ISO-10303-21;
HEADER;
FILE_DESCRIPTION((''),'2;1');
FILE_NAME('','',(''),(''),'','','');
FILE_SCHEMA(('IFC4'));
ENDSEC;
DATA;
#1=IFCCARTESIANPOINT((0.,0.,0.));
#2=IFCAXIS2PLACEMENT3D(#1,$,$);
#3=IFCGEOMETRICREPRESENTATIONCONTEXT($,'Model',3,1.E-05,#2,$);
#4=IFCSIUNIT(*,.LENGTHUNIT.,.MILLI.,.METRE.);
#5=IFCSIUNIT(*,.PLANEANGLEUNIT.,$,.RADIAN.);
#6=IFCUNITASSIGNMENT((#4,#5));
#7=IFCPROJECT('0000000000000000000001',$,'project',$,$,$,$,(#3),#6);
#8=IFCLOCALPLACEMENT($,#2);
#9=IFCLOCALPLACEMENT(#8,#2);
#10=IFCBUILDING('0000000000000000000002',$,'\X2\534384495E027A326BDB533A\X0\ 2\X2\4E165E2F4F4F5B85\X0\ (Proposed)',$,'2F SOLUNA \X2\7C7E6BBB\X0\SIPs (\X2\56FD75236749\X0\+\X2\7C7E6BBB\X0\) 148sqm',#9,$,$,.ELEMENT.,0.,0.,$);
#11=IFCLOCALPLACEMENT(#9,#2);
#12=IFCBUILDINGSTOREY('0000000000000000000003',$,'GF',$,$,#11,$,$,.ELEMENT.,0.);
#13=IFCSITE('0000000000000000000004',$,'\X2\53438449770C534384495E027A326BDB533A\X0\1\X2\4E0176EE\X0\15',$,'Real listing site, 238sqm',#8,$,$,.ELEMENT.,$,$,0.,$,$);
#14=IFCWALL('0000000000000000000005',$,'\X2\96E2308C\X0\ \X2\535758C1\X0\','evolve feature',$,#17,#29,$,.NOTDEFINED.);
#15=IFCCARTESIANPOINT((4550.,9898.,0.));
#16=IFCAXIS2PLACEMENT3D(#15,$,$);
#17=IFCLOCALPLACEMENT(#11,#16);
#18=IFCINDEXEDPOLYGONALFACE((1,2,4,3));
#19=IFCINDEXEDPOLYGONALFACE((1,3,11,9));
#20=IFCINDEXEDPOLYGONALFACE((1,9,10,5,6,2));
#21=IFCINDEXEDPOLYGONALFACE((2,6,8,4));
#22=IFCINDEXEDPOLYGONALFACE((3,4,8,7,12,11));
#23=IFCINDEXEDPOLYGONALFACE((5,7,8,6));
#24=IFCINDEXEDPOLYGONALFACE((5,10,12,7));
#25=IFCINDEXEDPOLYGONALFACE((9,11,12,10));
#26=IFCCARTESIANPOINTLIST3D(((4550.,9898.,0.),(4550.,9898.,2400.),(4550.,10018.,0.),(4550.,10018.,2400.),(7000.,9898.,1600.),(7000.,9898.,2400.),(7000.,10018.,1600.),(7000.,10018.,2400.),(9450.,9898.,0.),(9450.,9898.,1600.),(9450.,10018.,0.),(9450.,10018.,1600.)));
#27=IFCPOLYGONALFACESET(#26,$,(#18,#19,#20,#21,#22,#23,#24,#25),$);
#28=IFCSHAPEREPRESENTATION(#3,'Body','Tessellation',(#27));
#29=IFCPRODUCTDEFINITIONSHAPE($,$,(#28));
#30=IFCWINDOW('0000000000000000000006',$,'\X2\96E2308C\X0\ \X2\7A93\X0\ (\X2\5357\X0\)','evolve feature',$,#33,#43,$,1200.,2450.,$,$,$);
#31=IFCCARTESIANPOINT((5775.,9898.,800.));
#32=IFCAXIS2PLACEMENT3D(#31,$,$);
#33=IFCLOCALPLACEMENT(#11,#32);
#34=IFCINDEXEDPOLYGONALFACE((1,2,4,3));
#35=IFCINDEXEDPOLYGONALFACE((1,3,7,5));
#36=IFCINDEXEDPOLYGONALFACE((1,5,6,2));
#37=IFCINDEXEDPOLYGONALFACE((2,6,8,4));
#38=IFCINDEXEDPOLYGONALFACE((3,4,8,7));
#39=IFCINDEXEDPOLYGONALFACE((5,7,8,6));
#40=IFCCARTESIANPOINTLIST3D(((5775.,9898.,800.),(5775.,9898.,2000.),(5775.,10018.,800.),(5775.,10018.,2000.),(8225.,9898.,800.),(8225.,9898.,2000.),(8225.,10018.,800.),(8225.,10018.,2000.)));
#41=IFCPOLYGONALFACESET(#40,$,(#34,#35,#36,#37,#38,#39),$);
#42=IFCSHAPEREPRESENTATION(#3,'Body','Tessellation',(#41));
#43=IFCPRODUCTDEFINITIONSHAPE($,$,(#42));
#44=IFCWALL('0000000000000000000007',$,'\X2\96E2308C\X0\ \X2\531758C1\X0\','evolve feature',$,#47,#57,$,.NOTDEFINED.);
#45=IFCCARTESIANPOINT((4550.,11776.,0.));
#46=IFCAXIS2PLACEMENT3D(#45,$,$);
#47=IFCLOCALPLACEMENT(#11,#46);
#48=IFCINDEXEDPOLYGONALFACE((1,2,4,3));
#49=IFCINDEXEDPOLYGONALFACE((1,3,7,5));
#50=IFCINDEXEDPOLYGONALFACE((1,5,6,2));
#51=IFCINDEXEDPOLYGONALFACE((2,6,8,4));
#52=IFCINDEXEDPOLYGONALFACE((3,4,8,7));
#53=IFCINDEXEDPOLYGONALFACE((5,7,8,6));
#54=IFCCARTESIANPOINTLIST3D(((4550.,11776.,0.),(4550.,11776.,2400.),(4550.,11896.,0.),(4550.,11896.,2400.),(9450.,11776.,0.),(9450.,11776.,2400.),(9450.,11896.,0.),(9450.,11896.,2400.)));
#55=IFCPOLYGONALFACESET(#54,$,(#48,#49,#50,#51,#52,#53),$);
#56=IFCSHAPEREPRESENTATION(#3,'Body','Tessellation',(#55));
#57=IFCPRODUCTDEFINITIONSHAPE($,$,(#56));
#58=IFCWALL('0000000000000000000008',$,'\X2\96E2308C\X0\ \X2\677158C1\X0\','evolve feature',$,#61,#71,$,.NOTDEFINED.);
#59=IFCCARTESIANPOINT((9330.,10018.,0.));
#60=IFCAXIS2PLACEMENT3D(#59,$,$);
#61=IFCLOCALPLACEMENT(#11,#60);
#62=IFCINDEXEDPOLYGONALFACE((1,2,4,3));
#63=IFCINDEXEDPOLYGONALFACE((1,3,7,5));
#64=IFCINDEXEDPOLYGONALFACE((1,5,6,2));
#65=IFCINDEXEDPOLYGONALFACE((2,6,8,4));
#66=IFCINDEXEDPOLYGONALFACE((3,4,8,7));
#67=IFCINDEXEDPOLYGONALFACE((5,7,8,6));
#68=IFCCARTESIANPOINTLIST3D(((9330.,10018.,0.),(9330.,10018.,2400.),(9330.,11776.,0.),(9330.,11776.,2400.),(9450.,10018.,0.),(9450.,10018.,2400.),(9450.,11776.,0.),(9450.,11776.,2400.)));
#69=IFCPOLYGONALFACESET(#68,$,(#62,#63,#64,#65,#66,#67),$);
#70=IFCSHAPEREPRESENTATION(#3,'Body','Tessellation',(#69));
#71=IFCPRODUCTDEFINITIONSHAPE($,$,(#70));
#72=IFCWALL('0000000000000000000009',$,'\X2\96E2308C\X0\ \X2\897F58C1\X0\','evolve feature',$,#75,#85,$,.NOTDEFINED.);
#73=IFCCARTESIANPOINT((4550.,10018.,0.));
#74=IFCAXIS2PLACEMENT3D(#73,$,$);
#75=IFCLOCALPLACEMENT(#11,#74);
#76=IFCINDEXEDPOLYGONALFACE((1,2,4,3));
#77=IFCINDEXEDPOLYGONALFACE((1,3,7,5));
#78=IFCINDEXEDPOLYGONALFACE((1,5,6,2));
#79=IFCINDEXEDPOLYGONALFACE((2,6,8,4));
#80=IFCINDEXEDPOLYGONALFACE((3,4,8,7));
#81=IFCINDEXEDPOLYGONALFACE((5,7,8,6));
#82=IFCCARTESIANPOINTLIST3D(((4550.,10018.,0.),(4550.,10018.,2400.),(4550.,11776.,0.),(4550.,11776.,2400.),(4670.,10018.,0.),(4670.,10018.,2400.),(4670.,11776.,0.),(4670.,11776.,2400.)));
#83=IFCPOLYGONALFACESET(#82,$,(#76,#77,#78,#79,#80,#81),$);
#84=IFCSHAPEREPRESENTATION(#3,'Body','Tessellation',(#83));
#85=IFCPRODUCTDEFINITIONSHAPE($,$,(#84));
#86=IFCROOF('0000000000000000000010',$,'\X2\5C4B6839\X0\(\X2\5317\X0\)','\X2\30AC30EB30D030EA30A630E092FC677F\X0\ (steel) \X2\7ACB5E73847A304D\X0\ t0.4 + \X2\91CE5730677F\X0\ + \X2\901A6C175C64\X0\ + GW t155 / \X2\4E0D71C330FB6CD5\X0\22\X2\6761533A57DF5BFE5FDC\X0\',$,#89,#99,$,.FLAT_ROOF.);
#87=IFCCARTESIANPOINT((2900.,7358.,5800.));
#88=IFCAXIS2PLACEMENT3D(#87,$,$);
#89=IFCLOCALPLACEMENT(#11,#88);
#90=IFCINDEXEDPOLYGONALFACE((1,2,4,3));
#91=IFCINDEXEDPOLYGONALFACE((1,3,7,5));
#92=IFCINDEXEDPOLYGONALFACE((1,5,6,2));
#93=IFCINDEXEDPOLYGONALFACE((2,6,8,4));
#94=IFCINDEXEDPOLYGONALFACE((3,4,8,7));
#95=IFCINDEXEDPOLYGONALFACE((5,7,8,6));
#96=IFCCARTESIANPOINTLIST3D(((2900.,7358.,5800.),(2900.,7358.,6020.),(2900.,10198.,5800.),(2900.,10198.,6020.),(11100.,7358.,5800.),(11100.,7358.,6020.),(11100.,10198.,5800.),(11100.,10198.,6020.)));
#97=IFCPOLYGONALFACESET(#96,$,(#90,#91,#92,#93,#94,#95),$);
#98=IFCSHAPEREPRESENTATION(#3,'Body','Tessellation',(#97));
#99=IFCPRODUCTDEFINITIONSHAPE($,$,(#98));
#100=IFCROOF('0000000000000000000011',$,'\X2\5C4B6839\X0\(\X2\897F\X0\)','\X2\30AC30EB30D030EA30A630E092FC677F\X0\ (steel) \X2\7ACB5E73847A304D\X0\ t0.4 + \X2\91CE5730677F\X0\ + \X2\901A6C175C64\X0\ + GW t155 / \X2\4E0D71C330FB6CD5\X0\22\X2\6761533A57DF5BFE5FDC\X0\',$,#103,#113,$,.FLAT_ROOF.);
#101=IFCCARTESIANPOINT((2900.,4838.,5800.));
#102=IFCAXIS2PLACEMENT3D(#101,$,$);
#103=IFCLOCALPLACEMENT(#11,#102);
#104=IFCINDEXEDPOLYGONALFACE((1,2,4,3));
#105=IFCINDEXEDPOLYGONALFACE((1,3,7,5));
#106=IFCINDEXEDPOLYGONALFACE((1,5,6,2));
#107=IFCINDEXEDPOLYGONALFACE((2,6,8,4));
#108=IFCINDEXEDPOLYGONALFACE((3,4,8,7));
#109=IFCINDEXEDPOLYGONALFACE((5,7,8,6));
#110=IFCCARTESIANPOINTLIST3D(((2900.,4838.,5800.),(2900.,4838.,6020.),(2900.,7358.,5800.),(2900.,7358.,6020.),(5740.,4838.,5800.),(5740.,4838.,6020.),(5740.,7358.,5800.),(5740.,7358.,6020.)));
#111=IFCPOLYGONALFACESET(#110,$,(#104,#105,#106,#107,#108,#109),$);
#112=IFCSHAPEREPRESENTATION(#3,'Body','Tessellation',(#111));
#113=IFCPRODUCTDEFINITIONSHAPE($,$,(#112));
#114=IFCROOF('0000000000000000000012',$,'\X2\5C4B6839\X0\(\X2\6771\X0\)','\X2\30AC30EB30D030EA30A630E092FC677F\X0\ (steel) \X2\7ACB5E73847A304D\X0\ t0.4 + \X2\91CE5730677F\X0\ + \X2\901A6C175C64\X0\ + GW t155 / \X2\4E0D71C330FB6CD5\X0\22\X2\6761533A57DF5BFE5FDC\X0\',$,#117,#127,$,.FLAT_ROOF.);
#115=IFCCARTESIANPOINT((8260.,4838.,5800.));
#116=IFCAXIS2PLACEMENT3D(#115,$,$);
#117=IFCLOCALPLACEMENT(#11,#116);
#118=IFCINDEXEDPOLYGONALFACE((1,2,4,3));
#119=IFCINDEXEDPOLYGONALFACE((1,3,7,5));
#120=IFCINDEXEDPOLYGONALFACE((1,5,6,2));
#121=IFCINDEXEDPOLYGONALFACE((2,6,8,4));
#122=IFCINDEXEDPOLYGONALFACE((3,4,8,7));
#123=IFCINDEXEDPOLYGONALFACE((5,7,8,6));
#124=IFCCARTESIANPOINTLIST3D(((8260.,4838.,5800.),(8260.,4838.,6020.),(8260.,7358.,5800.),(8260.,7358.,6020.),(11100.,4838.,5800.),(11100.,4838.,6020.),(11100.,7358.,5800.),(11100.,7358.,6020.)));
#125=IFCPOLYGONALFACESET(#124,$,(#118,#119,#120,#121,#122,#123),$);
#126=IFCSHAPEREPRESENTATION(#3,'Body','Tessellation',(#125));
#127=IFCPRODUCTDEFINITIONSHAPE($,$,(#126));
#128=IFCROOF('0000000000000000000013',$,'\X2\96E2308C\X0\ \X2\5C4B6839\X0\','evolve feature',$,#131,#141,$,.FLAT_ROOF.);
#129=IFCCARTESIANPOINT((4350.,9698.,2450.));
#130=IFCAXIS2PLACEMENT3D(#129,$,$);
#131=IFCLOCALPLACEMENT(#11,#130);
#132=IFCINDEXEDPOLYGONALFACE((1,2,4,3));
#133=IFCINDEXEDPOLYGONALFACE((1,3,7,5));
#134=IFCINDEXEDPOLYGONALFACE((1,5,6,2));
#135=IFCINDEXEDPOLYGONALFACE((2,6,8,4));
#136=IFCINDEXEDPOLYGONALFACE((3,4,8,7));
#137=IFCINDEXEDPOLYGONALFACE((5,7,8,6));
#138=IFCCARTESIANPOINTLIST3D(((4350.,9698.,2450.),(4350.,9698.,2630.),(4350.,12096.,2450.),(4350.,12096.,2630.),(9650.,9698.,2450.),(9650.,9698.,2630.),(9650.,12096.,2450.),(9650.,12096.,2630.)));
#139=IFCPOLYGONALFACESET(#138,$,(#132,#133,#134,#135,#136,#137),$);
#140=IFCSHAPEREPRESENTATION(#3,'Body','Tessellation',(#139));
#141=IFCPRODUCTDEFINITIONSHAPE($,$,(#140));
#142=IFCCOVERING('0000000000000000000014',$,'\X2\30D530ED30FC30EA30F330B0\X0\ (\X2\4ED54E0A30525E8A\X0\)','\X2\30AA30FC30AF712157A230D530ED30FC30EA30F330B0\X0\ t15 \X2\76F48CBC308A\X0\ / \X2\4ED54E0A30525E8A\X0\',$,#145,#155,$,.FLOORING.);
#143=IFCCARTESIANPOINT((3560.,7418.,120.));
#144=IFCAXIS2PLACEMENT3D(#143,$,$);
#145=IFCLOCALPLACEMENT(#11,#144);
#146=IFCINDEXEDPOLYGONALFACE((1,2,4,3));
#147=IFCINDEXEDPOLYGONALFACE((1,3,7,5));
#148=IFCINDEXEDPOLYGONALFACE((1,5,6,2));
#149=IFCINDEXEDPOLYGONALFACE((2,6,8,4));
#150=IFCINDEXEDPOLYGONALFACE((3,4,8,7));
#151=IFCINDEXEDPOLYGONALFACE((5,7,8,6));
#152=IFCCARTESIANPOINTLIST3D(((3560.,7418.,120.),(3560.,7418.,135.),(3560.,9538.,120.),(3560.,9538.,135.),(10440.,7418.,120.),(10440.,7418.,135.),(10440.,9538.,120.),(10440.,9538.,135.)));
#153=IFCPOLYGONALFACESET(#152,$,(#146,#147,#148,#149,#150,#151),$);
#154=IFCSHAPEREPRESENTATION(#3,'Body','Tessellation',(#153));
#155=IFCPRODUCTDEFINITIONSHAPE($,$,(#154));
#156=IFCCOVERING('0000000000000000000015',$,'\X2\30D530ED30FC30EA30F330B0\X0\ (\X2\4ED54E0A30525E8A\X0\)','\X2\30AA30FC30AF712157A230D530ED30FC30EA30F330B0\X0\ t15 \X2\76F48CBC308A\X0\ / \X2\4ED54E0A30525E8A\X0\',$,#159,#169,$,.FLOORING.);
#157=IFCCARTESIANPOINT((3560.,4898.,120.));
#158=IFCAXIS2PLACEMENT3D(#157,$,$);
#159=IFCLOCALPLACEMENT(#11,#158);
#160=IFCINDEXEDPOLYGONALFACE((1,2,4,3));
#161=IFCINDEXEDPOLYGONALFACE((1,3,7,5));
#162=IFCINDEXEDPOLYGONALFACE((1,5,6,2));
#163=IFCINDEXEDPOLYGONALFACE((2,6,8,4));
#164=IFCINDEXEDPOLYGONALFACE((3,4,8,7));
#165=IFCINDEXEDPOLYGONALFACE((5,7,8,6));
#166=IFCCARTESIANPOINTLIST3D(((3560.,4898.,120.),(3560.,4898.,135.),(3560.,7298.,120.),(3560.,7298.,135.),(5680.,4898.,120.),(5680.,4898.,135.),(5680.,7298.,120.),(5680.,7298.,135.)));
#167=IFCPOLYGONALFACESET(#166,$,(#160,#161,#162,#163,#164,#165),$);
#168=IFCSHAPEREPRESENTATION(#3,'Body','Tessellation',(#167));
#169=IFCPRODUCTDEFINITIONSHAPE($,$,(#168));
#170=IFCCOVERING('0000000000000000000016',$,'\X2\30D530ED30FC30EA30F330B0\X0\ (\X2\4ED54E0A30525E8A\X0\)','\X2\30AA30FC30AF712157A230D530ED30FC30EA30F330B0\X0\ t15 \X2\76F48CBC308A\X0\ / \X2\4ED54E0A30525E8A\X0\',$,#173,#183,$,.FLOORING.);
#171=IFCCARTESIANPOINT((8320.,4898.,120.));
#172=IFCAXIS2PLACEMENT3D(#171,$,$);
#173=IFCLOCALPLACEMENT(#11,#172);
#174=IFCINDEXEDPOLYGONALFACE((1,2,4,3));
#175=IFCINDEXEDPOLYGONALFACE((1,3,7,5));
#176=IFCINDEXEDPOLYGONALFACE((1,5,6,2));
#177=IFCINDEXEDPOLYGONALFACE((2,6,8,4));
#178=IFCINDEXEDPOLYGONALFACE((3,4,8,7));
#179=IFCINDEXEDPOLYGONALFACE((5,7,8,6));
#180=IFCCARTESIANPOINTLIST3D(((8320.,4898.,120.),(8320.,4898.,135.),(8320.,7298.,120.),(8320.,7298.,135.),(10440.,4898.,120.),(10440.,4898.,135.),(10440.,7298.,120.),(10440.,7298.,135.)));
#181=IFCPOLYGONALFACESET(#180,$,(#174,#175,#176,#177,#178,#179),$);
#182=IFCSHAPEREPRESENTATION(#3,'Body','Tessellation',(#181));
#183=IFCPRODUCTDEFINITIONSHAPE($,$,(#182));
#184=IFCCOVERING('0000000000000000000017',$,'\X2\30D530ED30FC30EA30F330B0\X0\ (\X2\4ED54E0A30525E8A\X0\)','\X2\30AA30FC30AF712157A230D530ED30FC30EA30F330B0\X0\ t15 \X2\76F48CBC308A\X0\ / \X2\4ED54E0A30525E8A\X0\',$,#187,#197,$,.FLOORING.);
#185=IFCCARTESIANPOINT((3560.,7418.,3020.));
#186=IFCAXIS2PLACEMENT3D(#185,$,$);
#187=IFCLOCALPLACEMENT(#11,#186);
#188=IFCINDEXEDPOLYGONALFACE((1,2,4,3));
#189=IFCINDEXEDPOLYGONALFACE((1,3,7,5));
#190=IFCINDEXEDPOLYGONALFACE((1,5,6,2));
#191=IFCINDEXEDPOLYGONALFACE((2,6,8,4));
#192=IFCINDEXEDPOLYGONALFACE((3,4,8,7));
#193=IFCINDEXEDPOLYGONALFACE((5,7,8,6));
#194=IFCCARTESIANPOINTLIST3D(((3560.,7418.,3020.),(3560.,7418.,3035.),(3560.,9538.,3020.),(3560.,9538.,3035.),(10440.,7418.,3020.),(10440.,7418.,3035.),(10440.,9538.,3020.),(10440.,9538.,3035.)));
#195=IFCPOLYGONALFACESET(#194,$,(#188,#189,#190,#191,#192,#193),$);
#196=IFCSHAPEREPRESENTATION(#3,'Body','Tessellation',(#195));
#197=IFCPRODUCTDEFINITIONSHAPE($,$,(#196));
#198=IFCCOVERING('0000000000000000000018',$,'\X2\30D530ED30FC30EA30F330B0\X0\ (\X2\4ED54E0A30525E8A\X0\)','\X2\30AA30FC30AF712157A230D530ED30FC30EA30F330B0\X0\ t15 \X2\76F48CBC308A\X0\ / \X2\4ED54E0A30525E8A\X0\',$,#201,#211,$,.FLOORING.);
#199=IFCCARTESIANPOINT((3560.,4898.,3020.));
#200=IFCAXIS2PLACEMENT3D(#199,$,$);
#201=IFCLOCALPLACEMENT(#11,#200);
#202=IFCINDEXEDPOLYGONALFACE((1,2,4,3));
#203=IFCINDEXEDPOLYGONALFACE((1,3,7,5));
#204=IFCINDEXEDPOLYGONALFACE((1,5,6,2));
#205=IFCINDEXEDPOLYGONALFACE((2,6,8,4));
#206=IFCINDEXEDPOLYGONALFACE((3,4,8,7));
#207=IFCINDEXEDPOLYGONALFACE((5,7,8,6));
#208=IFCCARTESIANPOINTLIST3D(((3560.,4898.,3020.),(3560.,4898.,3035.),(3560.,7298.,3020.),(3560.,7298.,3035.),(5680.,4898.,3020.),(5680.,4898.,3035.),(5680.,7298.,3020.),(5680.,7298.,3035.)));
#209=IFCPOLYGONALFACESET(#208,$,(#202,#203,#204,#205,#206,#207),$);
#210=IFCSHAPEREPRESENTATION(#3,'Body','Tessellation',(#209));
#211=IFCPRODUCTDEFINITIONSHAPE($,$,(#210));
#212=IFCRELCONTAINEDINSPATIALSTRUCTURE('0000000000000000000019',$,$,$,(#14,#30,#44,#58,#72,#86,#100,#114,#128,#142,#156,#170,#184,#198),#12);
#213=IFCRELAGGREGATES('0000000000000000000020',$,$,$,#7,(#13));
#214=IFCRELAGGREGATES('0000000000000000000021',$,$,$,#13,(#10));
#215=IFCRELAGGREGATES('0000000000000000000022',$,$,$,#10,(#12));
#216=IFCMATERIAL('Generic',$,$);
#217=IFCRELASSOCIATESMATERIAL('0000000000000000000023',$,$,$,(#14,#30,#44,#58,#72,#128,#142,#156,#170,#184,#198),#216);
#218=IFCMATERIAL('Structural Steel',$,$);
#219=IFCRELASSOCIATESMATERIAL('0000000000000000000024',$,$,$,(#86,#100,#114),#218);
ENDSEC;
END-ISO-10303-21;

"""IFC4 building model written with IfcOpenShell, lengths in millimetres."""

from ifc_helpers import new_model, si_unit, frame, frame_2d, origin, place, context, project, spatial, rectangle, extrude, material, element, fill, save


model = new_model("IFC4")

# Units and contexts
model_context = context("Model", 3, precision=1e-05, world=origin())
ifc_project = project(units=[si_unit("LENGTHUNIT", "METRE", prefix="MILLI"), si_unit("PLANEANGLEUNIT", "RADIAN")], contexts=[model_context])

# Site, building, storey
site_placement = place(None, origin())
site = spatial("IfcSite", under=ifc_project, at=site_placement, Name="千葉県千葉市稲毛区1丁目15", ObjectType="Real listing site, 238sqm", CompositionType="ELEMENT", RefElevation=0.0)
building_placement = place(site_placement, origin())
building = spatial("IfcBuilding", under=site, at=building_placement, Name="千葉市稲毛区 2世帯住宅 (Proposed)", ObjectType="2F SOLUNA 籾殻SIPs (国産杉+籾殻) 148sqm", CompositionType="ELEMENT", ElevationOfRefHeight=0.0, ElevationOfTerrain=0.0)
storey_placement = place(building_placement, origin())
storey = spatial("IfcBuildingStorey", under=building, at=storey_placement, Name="GF", CompositionType="ELEMENT", Elevation=0.0)

# Shared definitions
ifc_material_1 = material(Name="Generic")

# Wall, opening, window
wall_1_placement = place(storey_placement, frame((4550.0, 9898.0, 0.0)))
wall_1 = element("IfcWall", 1, at=wall_1_placement, inside=storey, material=ifc_material_1, Name="離れ 南壁", Description="evolve feature", PredefinedType="NOTDEFINED", context=model_context, shape_type="SweptSolid", body=[
    extrude(rectangle(XDim=4900.0, YDim=120.0, at=frame_2d((2450.0, 60.0))), frame((4550.0, 9898.0, 0.0)), (0.0, 0.0, 1.0), 2400.0),
])
opening_1_placement = place(storey_placement, frame((5775.0, 9898.0, 800.0)))
opening_1 = element("IfcOpeningElement", 2, at=opening_1_placement, cuts=wall_1, PredefinedType="NOTDEFINED", context=model_context, shape_type="SweptSolid", body=[
    extrude(rectangle(XDim=2450.0, YDim=120.0, at=frame_2d((1225.0, 60.0))), frame((5775.0, 9898.0, 800.0)), (0.0, 0.0, 1.0), 1200.0),
])
window_1_placement = place(storey_placement, frame((5775.0, 9898.0, 800.0)))
window_1 = element("IfcWindow", 3, at=window_1_placement, inside=storey, material=ifc_material_1, Name="離れ 窓 (南)", Description="evolve feature", OverallHeight=1200.0, OverallWidth=2450.0, context=model_context, shape_type="SweptSolid", body=[
    extrude(rectangle(XDim=2450.0, YDim=120.0, at=frame_2d((1225.0, 60.0))), frame((5775.0, 9898.0, 800.0)), (0.0, 0.0, 1.0), 1200.0),
])
fill(opening_1, window_1)

# Walls
wall_2_placement = place(storey_placement, frame((4550.0, 11776.0, 0.0)))
element("IfcWall", 4, at=wall_2_placement, inside=storey, material=ifc_material_1, Name="離れ 北壁", Description="evolve feature", PredefinedType="NOTDEFINED", context=model_context, shape_type="SweptSolid", body=[
    extrude(rectangle(XDim=4900.0, YDim=120.0, at=frame_2d((2450.0, 60.0))), frame((4550.0, 11776.0, 0.0)), (0.0, 0.0, 1.0), 2400.0),
])
wall_3_placement = place(storey_placement, frame((9330.0, 10018.0, 0.0)))
element("IfcWall", 5, at=wall_3_placement, inside=storey, material=ifc_material_1, Name="離れ 東壁", Description="evolve feature", PredefinedType="NOTDEFINED", context=model_context, shape_type="SweptSolid", body=[
    extrude(rectangle(XDim=120.0, YDim=1758.0, at=frame_2d((60.0, 879.0))), frame((9330.0, 10018.0, 0.0)), (0.0, 0.0, 1.0), 2400.0),
])
wall_4_placement = place(storey_placement, frame((4550.0, 10018.0, 0.0)))
element("IfcWall", 6, at=wall_4_placement, inside=storey, material=ifc_material_1, Name="離れ 西壁", Description="evolve feature", PredefinedType="NOTDEFINED", context=model_context, shape_type="SweptSolid", body=[
    extrude(rectangle(XDim=120.0, YDim=1758.0, at=frame_2d((60.0, 879.0))), frame((4550.0, 10018.0, 0.0)), (0.0, 0.0, 1.0), 2400.0),
])

# Roofs
ifc_material_2 = material(Name="Structural Steel")
for number, where, name in (
    (7, (2900.0, 7358.0, 5800.0), "屋根(北)"),
):
    element("IfcRoof", number, at=place(storey_placement, frame(where)), inside=storey, material=ifc_material_2, Name=name, Description="ガルバリウム鋼板 (steel) 立平葺き t0.4 + 野地板 + 通気層 + GW t155 / 不燃・法22条区域対応", PredefinedType="FLAT_ROOF", context=model_context, shape_type="SweptSolid", body=[
        extrude(rectangle(XDim=8200.0, YDim=2840.0, at=frame_2d((4100.0, 1420.0))), frame((2900.0, 7358.0, 5800.0)), (0.0, 0.0, 1.0), 220.0),
    ])
roof_1_placement = place(storey_placement, frame((2900.0, 4838.0, 5800.0)))
element("IfcRoof", 8, at=roof_1_placement, inside=storey, material=ifc_material_2, Name="屋根(西)", Description="ガルバリウム鋼板 (steel) 立平葺き t0.4 + 野地板 + 通気層 + GW t155 / 不燃・法22条区域対応", PredefinedType="FLAT_ROOF", context=model_context, shape_type="SweptSolid", body=[
    extrude(rectangle(XDim=2840.0, YDim=2520.0, at=frame_2d((1420.0, 1260.0))), frame((2900.0, 4838.0, 5800.0)), (0.0, 0.0, 1.0), 220.0),
])
roof_2_placement = place(storey_placement, frame((8260.0, 4838.0, 5800.0)))
element("IfcRoof", 9, at=roof_2_placement, inside=storey, material=ifc_material_2, Name="屋根(東)", Description="ガルバリウム鋼板 (steel) 立平葺き t0.4 + 野地板 + 通気層 + GW t155 / 不燃・法22条区域対応", PredefinedType="FLAT_ROOF", context=model_context, shape_type="SweptSolid", body=[
    extrude(rectangle(XDim=2840.0, YDim=2520.0, at=frame_2d((1420.0, 1260.0))), frame((8260.0, 4838.0, 5800.0)), (0.0, 0.0, 1.0), 220.0),
])
roof_3_placement = place(storey_placement, frame((4350.0, 9698.0, 2450.0)))
element("IfcRoof", 10, at=roof_3_placement, inside=storey, material=ifc_material_1, Name="離れ 屋根", Description="evolve feature", PredefinedType="FLAT_ROOF", context=model_context, shape_type="SweptSolid", body=[
    extrude(rectangle(XDim=5300.0, YDim=2398.0, at=frame_2d((2650.0, 1199.0))), frame((4350.0, 9698.0, 2450.0)), (0.0, 0.0, 1.0), 180.0),
])

# Coverings
covering_1_placement = place(storey_placement, frame((3560.0, 7418.0, 120.0)))
element("IfcCovering", 11, at=covering_1_placement, inside=storey, material=ifc_material_1, Name="フローリング (仕上げ床)", Description="オーク無垢フローリング t15 直貼り / 仕上げ床", PredefinedType="FLOORING", context=model_context, shape_type="SweptSolid", body=[
    extrude(rectangle(XDim=6880.0, YDim=2120.0, at=frame_2d((3440.0, 1060.0))), frame((3560.0, 7418.0, 120.0)), (0.0, 0.0, 1.0), 15.0),
])
covering_2_placement = place(storey_placement, frame((3560.0, 4898.0, 120.0)))
element("IfcCovering", 12, at=covering_2_placement, inside=storey, material=ifc_material_1, Name="フローリング (仕上げ床)", Description="オーク無垢フローリング t15 直貼り / 仕上げ床", PredefinedType="FLOORING", context=model_context, shape_type="SweptSolid", body=[
    extrude(rectangle(XDim=2120.0, YDim=2400.0, at=frame_2d((1060.0, 1200.0))), frame((3560.0, 4898.0, 120.0)), (0.0, 0.0, 1.0), 15.0),
])
covering_3_placement = place(storey_placement, frame((8320.0, 4898.0, 120.0)))
element("IfcCovering", 13, at=covering_3_placement, inside=storey, material=ifc_material_1, Name="フローリング (仕上げ床)", Description="オーク無垢フローリング t15 直貼り / 仕上げ床", PredefinedType="FLOORING", context=model_context, shape_type="SweptSolid", body=[
    extrude(rectangle(XDim=2120.0, YDim=2400.0, at=frame_2d((1060.0, 1200.0))), frame((8320.0, 4898.0, 120.0)), (0.0, 0.0, 1.0), 15.0),
])
covering_4_placement = place(storey_placement, frame((3560.0, 7418.0, 3020.0)))
element("IfcCovering", 14, at=covering_4_placement, inside=storey, material=ifc_material_1, Name="フローリング (仕上げ床)", Description="オーク無垢フローリング t15 直貼り / 仕上げ床", PredefinedType="FLOORING", context=model_context, shape_type="SweptSolid", body=[
    extrude(rectangle(XDim=6880.0, YDim=2120.0, at=frame_2d((3440.0, 1060.0))), frame((3560.0, 7418.0, 3020.0)), (0.0, 0.0, 1.0), 15.0),
])
covering_5_placement = place(storey_placement, frame((3560.0, 4898.0, 3020.0)))
element("IfcCovering", 15, at=covering_5_placement, inside=storey, material=ifc_material_1, Name="フローリング (仕上げ床)", Description="オーク無垢フローリング t15 直貼り / 仕上げ床", PredefinedType="FLOORING", context=model_context, shape_type="SweptSolid", body=[
    extrude(rectangle(XDim=2120.0, YDim=2400.0, at=frame_2d((1060.0, 1200.0))), frame((3560.0, 4898.0, 3020.0)), (0.0, 0.0, 1.0), 15.0),
])

save(model, "model.ifc")
